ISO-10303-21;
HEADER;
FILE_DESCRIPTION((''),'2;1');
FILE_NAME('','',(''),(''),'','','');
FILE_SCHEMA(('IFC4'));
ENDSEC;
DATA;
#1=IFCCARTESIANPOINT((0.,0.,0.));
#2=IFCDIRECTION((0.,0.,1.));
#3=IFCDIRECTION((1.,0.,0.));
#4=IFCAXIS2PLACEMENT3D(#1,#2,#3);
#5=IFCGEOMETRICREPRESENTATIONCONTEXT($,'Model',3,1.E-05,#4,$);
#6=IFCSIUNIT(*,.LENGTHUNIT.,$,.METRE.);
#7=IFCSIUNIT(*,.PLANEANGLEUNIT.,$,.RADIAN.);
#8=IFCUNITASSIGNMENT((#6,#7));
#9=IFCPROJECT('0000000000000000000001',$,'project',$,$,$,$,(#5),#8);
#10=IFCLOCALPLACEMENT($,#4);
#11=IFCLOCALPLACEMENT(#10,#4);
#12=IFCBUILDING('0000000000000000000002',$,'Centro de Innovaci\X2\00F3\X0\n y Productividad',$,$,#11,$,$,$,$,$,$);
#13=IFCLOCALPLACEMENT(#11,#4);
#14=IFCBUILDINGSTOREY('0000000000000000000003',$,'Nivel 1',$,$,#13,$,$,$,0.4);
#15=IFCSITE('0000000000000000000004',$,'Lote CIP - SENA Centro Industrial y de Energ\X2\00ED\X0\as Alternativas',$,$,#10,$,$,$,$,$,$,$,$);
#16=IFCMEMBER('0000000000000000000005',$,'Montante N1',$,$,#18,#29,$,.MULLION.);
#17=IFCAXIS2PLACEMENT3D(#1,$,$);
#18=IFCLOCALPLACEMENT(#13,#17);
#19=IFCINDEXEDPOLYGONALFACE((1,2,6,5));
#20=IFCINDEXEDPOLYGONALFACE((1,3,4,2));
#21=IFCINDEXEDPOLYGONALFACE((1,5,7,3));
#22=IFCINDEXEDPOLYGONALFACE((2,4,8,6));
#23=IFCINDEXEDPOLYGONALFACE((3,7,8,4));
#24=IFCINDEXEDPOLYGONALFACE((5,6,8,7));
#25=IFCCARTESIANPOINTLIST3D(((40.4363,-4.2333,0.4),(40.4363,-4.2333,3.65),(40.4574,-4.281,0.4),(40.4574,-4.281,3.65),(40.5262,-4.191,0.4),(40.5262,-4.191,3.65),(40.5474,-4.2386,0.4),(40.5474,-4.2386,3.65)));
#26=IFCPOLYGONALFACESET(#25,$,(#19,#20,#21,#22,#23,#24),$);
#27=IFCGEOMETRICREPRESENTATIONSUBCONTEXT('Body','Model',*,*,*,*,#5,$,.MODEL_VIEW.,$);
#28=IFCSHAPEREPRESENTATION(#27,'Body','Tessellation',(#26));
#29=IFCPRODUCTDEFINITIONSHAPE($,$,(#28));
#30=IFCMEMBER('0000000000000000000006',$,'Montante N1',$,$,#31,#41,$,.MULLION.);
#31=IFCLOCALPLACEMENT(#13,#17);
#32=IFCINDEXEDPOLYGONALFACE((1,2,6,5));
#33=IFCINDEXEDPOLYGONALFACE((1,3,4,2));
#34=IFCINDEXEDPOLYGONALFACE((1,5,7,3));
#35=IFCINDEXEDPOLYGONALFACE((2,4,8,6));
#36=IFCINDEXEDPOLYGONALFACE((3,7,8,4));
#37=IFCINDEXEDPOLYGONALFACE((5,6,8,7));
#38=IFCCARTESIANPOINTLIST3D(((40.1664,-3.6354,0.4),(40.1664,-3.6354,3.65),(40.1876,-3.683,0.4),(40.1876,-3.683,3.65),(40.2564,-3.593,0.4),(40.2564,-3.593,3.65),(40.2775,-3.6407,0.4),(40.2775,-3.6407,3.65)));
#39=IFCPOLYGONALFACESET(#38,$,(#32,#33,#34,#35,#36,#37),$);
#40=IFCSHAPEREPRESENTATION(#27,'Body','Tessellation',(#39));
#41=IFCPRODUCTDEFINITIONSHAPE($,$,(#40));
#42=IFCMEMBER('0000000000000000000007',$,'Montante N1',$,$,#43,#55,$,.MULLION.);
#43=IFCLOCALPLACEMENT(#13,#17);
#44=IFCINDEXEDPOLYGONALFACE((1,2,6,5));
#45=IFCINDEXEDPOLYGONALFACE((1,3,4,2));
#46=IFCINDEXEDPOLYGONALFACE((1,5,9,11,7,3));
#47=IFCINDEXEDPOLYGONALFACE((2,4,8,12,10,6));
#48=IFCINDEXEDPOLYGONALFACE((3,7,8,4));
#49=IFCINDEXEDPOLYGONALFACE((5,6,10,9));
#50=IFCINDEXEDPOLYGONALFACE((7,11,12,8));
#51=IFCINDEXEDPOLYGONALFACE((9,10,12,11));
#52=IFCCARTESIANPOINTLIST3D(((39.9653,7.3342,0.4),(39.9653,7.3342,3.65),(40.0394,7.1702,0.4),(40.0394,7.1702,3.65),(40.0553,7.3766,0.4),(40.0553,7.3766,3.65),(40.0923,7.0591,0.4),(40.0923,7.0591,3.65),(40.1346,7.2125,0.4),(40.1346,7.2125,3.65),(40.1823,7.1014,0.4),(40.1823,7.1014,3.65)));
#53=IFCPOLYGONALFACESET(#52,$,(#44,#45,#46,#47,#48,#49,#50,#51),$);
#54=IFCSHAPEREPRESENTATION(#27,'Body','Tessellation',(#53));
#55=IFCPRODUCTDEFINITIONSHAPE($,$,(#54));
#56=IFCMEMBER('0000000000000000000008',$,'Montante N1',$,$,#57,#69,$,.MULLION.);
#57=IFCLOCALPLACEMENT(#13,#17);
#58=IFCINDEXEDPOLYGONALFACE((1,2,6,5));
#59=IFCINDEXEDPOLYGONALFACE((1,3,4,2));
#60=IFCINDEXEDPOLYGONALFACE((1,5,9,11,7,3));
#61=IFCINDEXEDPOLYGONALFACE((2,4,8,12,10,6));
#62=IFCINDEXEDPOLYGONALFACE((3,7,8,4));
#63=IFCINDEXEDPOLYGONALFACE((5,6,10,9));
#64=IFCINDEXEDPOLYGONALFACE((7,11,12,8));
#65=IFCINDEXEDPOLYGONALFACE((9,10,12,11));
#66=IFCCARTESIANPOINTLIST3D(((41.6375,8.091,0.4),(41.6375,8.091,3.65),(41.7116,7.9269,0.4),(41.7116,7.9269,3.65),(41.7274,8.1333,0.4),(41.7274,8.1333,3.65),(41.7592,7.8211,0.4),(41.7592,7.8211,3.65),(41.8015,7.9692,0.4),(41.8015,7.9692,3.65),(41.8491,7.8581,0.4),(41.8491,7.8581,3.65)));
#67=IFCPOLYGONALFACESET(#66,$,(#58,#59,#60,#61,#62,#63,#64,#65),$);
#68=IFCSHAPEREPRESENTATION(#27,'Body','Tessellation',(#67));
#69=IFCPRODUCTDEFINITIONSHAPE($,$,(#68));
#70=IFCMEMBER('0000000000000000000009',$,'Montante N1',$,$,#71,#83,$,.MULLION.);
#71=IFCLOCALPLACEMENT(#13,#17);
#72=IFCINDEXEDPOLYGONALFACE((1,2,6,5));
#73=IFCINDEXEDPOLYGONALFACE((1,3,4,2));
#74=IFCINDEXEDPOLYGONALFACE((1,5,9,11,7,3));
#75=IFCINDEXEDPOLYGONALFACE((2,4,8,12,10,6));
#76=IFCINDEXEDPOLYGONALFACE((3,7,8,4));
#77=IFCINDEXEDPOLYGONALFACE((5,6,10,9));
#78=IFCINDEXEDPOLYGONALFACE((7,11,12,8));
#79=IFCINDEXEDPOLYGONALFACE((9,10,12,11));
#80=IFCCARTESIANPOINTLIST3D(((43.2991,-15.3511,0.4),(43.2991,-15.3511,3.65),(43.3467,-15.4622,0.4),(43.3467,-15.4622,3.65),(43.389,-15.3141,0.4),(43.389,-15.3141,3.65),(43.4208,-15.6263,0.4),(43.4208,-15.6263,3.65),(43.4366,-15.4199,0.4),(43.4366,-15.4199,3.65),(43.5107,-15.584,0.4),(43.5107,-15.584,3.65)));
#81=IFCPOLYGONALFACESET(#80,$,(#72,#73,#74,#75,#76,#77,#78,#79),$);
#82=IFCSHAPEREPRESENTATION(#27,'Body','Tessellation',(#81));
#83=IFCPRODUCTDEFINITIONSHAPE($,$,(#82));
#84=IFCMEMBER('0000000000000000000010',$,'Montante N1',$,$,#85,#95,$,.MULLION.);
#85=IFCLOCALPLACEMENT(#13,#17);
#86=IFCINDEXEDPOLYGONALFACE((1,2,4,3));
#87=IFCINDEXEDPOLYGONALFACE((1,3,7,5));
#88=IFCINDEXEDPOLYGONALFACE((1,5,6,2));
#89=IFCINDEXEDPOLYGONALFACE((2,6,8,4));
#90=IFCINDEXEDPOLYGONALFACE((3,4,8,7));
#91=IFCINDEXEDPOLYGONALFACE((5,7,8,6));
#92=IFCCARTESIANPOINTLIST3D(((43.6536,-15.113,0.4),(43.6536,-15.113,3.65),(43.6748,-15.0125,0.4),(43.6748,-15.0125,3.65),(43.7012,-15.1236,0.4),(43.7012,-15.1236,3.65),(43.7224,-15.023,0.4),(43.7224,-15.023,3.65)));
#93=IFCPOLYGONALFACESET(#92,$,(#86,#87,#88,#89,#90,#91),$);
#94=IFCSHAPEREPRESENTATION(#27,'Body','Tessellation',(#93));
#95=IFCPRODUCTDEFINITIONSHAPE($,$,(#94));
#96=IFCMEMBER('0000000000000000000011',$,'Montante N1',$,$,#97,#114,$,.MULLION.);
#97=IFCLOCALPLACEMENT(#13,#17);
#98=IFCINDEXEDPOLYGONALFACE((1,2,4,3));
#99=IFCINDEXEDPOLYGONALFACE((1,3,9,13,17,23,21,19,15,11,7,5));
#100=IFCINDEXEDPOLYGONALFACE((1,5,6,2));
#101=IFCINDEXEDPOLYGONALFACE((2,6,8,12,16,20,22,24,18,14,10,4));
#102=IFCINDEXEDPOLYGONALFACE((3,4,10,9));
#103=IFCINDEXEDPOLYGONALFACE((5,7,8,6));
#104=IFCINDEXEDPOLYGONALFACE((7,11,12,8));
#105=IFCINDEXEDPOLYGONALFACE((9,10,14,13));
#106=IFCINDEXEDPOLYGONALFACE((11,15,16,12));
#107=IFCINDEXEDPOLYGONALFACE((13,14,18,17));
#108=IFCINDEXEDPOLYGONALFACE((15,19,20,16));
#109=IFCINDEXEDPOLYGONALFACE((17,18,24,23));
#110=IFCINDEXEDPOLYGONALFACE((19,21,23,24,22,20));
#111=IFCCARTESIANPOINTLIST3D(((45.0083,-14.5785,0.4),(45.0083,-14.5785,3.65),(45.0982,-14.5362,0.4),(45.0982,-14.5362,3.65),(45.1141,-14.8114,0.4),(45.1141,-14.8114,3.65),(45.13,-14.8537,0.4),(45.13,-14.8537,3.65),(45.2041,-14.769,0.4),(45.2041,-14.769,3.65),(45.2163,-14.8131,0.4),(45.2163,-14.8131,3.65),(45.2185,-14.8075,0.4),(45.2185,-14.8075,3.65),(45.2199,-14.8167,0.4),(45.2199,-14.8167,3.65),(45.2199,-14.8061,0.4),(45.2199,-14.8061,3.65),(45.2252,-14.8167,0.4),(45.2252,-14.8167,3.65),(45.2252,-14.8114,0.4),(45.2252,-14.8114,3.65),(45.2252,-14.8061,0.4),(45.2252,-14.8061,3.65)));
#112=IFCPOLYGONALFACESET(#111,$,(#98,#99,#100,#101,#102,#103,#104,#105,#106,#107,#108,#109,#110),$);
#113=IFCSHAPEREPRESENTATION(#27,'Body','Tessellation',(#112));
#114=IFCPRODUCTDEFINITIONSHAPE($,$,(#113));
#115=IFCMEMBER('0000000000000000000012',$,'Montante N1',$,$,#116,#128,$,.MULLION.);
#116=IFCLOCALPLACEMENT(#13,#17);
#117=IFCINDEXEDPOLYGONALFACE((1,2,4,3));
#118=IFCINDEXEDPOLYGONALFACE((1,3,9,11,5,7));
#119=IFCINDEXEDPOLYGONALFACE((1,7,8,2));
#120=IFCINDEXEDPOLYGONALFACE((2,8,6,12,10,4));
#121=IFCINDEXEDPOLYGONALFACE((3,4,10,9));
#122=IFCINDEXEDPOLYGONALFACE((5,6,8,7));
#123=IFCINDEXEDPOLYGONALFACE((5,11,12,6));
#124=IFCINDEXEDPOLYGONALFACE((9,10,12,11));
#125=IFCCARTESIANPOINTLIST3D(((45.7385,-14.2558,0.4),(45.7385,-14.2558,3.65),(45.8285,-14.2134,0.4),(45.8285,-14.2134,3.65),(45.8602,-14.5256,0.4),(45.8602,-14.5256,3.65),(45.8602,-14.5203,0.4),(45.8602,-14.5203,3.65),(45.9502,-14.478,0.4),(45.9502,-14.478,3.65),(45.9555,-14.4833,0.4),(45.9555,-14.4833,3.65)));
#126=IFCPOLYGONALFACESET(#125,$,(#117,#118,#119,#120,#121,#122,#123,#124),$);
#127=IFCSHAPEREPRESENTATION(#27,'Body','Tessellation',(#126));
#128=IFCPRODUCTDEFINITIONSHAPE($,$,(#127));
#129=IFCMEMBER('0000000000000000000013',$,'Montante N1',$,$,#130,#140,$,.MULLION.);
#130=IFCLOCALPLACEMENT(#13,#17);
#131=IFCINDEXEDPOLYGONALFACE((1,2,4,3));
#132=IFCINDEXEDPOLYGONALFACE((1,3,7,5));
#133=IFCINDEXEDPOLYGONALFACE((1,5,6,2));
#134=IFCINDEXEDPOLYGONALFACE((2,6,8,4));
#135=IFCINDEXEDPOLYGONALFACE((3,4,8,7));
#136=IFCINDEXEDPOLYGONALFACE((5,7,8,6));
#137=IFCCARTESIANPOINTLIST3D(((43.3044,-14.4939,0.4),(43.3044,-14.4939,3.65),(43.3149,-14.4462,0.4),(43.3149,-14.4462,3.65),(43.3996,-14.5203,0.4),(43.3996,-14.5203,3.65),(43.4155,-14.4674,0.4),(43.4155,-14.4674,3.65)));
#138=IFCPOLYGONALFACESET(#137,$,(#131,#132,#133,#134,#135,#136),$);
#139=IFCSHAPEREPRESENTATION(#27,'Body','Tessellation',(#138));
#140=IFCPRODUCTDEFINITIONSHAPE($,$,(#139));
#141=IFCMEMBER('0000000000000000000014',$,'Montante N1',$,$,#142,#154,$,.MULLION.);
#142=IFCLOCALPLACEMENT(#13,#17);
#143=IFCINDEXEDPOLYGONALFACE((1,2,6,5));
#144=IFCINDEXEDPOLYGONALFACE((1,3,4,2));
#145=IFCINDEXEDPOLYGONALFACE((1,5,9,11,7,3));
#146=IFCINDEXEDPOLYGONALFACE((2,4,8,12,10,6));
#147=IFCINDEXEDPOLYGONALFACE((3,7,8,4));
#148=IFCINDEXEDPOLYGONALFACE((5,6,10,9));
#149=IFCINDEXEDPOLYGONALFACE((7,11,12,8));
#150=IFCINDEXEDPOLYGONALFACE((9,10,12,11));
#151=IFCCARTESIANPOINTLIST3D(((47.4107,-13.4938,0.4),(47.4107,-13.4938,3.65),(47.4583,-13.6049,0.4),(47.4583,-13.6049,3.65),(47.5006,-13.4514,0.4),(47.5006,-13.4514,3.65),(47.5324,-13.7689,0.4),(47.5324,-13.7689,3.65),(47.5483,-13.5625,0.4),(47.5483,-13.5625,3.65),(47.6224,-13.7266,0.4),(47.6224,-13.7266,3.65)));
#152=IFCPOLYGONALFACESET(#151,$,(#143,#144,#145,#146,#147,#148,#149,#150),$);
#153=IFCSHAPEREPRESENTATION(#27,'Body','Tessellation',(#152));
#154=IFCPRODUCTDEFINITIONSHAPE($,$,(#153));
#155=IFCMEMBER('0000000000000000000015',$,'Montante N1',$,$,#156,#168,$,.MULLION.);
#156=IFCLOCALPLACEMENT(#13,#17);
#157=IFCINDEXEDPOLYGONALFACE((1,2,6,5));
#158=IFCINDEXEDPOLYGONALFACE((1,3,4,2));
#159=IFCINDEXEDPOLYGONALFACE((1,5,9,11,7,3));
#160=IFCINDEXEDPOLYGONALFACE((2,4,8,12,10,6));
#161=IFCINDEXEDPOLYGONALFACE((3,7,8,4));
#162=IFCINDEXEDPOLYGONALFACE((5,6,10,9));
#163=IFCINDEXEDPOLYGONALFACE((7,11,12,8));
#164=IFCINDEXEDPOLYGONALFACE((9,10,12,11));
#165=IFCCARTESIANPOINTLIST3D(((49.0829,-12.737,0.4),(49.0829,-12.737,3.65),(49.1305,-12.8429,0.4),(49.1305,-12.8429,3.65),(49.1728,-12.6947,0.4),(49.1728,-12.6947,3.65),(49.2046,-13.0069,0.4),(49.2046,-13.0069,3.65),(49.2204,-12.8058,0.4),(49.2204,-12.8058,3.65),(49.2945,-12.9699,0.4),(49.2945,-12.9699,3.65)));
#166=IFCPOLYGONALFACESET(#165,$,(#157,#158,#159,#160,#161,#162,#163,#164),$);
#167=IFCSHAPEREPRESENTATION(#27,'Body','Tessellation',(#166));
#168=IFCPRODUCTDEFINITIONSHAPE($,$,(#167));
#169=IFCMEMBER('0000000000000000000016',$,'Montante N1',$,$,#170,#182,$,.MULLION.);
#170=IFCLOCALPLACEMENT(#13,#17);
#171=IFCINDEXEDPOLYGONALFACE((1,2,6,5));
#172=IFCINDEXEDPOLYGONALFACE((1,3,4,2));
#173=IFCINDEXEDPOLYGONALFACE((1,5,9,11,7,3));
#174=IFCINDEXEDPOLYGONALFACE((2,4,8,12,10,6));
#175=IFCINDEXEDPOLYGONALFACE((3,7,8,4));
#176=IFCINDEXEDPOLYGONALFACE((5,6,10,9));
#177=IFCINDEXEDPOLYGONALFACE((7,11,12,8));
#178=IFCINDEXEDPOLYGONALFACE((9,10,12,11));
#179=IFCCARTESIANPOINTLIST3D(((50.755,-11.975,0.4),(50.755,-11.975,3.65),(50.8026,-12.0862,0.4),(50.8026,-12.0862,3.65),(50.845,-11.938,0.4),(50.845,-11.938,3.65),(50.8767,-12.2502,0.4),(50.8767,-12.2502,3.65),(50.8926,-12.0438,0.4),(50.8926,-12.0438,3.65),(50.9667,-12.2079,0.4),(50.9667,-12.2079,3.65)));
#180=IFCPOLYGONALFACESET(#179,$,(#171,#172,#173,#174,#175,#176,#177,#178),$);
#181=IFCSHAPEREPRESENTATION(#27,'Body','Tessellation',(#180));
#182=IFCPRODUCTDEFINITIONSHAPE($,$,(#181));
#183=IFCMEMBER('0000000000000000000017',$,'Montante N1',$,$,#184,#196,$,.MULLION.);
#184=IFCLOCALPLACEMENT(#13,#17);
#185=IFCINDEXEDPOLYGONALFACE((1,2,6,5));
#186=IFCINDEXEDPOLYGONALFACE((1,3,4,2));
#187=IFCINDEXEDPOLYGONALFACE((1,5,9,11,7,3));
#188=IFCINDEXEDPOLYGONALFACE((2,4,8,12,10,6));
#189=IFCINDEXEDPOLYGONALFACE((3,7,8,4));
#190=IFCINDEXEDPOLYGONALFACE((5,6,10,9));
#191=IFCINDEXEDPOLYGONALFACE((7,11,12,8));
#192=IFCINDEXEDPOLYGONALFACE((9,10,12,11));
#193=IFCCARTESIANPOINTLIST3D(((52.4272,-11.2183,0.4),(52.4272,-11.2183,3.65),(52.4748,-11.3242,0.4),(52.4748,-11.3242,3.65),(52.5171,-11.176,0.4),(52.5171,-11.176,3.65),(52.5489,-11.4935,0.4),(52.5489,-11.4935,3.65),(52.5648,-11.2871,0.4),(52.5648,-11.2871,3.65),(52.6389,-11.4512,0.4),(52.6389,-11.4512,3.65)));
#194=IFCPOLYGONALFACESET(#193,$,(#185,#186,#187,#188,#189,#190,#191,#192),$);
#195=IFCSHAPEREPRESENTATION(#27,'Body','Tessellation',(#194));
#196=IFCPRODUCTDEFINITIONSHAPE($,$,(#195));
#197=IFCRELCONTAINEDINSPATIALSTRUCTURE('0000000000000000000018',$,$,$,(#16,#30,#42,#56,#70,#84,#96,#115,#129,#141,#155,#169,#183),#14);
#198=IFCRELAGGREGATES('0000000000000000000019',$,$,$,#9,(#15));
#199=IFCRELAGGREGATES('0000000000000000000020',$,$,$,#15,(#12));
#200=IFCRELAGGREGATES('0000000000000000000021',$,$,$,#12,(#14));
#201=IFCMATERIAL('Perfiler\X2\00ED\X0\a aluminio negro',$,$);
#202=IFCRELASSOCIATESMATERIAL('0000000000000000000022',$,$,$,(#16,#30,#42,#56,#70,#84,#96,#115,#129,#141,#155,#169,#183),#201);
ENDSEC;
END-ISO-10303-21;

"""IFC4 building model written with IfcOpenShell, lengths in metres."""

from ifc_helpers import new_model, si_unit, frame, origin_with_axes, place, context, subcontext, project, spatial, polyline, outline, extrude, material, element, save


model = new_model("IFC4")

# Units and contexts
model_context = context("Model", 3, precision=1e-05, world=origin_with_axes())
body_context = subcontext(model_context, "Body", "Model", "MODEL_VIEW")
ifc_project = project(units=[si_unit("LENGTHUNIT", "METRE"), si_unit("PLANEANGLEUNIT", "RADIAN")], contexts=[model_context])

# Site, building, storey
site_placement = place(None, origin_with_axes())
site = spatial("IfcSite", under=ifc_project, at=site_placement, Name="Lote CIP - SENA Centro Industrial y de Energías Alternativas")
building_placement = place(site_placement, origin_with_axes())
building = spatial("IfcBuilding", under=site, at=building_placement, Name="Centro de Innovación y Productividad")
storey_placement = place(building_placement, origin_with_axes())
storey = spatial("IfcBuildingStorey", under=building, at=storey_placement, Name="Nivel 1", Elevation=0.4)

# Members
ifc_material = material(Name="Perfilería aluminio negro")
member_1_placement = place(storey_placement, origin_with_axes())
element("IfcMember", 1, at=member_1_placement, inside=storey, material=ifc_material, Name="Montante N1", PredefinedType="MULLION", context=body_context, shape_type="SweptSolid", body=[
    extrude(outline(polyline([(40.4574, -4.281), (40.4363, -4.2333), (40.5262, -4.191), (40.5474, -4.2386), (40.4574, -4.281)])), frame((0.0, 0.0, 0.4)), (0.0, 0.0, 1.0), 3.25),
])
member_2_placement = place(storey_placement, origin_with_axes())
element("IfcMember", 2, at=member_2_placement, inside=storey, material=ifc_material, Name="Montante N1", PredefinedType="MULLION", context=body_context, shape_type="SweptSolid", body=[
    extrude(outline(polyline([(40.1876, -3.683), (40.1664, -3.6354), (40.2564, -3.593), (40.2775, -3.6407), (40.1876, -3.683)])), frame((0.0, 0.0, 0.4)), (0.0, 0.0, 1.0), 3.25),
])
member_3_placement = place(storey_placement, origin_with_axes())
element("IfcMember", 3, at=member_3_placement, inside=storey, material=ifc_material, Name="Montante N1", PredefinedType="MULLION", context=body_context, shape_type="SweptSolid", body=[
    extrude(outline(polyline([(40.1346, 7.2125), (40.1823, 7.1014), (40.0923, 7.0591), (40.0394, 7.1702), (39.9653, 7.3342), (40.0553, 7.3766), (40.1346, 7.2125)])), frame((0.0, 0.0, 0.4)), (0.0, 0.0, 1.0), 3.25),
])
member_4_placement = place(storey_placement, origin_with_axes())
element("IfcMember", 4, at=member_4_placement, inside=storey, material=ifc_material, Name="Montante N1", PredefinedType="MULLION", context=body_context, shape_type="SweptSolid", body=[
    extrude(outline(polyline([(41.6375, 8.091), (41.7274, 8.1333), (41.8015, 7.9692), (41.8491, 7.8581), (41.7592, 7.8211), (41.7116, 7.9269), (41.6375, 8.091)])), frame((0.0, 0.0, 0.4)), (0.0, 0.0, 1.0), 3.25),
])
member_5_placement = place(storey_placement, origin_with_axes())
element("IfcMember", 5, at=member_5_placement, inside=storey, material=ifc_material, Name="Montante N1", PredefinedType="MULLION", context=body_context, shape_type="SweptSolid", body=[
    extrude(outline(polyline([(43.389, -15.3141), (43.4366, -15.4199), (43.5107, -15.584), (43.4208, -15.6263), (43.3467, -15.4623), (43.2991, -15.3511), (43.389, -15.3141)])), frame((0.0, 0.0, 0.4)), (0.0, 0.0, 1.0), 3.25),
])
member_6_placement = place(storey_placement, origin_with_axes())
element("IfcMember", 6, at=member_6_placement, inside=storey, material=ifc_material, Name="Montante N1", PredefinedType="MULLION", context=body_context, shape_type="SweptSolid", body=[
    extrude(outline(polyline([(43.6536, -15.113), (43.6748, -15.0125), (43.7224, -15.023), (43.7012, -15.1236), (43.6536, -15.113)])), frame((0.0, 0.0, 0.4)), (0.0, 0.0, 1.0), 3.25),
])
member_7_placement = place(storey_placement, origin_with_axes())
element("IfcMember", 7, at=member_7_placement, inside=storey, material=ifc_material, Name="Montante N1", PredefinedType="MULLION", context=body_context, shape_type="SweptSolid", body=[
    extrude(outline(polyline([(45.2199, -14.8061), (45.2252, -14.8061), (45.2252, -14.8114), (45.2252, -14.8167), (45.2199, -14.8167), (45.2163, -14.8131), (45.13, -14.8537), (45.1141, -14.8114), (45.0083, -14.5785), (45.0982, -14.5362), (45.2041, -14.769), (45.2185, -14.8075), (45.2199, -14.8061)])), frame((0.0, 0.0, 0.4)), (0.0, 0.0, 1.0), 3.25),
])
member_8_placement = place(storey_placement, origin_with_axes())
element("IfcMember", 8, at=member_8_placement, inside=storey, material=ifc_material, Name="Montante N1", PredefinedType="MULLION", context=body_context, shape_type="SweptSolid", body=[
    extrude(outline(polyline([(45.8602, -14.5203), (45.7385, -14.2558), (45.8285, -14.2134), (45.9502, -14.478), (45.9555, -14.4833), (45.8602, -14.5256), (45.8602, -14.5203)])), frame((0.0, 0.0, 0.4)), (0.0, 0.0, 1.0), 3.25),
])
member_9_placement = place(storey_placement, origin_with_axes())
element("IfcMember", 9, at=member_9_placement, inside=storey, material=ifc_material, Name="Montante N1", PredefinedType="MULLION", context=body_context, shape_type="SweptSolid", body=[
    extrude(outline(polyline([(43.3044, -14.4939), (43.3149, -14.4462), (43.4155, -14.4674), (43.3996, -14.5203), (43.3044, -14.4939)])), frame((0.0, 0.0, 0.4)), (0.0, 0.0, 1.0), 3.25),
])
member_10_placement = place(storey_placement, origin_with_axes())
element("IfcMember", 10, at=member_10_placement, inside=storey, material=ifc_material, Name="Montante N1", PredefinedType="MULLION", context=body_context, shape_type="SweptSolid", body=[
    extrude(outline(polyline([(47.5006, -13.4514), (47.5483, -13.5625), (47.6224, -13.7266), (47.5324, -13.7689), (47.4583, -13.6049), (47.4107, -13.4938), (47.5006, -13.4514)])), frame((0.0, 0.0, 0.4)), (0.0, 0.0, 1.0), 3.25),
])
member_11_placement = place(storey_placement, origin_with_axes())
element("IfcMember", 11, at=member_11_placement, inside=storey, material=ifc_material, Name="Montante N1", PredefinedType="MULLION", context=body_context, shape_type="SweptSolid", body=[
    extrude(outline(polyline([(49.2204, -12.8058), (49.2945, -12.9699), (49.2046, -13.0069), (49.1305, -12.8429), (49.0829, -12.737), (49.1728, -12.6947), (49.2204, -12.8058)])), frame((0.0, 0.0, 0.4)), (0.0, 0.0, 1.0), 3.25),
])
member_12_placement = place(storey_placement, origin_with_axes())
element("IfcMember", 12, at=member_12_placement, inside=storey, material=ifc_material, Name="Montante N1", PredefinedType="MULLION", context=body_context, shape_type="SweptSolid", body=[
    extrude(outline(polyline([(50.755, -11.975), (50.845, -11.938), (50.8926, -12.0438), (50.9667, -12.2079), (50.8767, -12.2502), (50.8026, -12.0862), (50.755, -11.975)])), frame((0.0, 0.0, 0.4)), (0.0, 0.0, 1.0), 3.25),
])
member_13_placement = place(storey_placement, origin_with_axes())
element("IfcMember", 13, at=member_13_placement, inside=storey, material=ifc_material, Name="Montante N1", PredefinedType="MULLION", context=body_context, shape_type="SweptSolid", body=[
    extrude(outline(polyline([(52.5489, -11.4935), (52.4748, -11.3242), (52.4272, -11.2183), (52.5171, -11.176), (52.5648, -11.2871), (52.6389, -11.4512), (52.5489, -11.4935)])), frame((0.0, 0.0, 0.4)), (0.0, 0.0, 1.0), 3.25),
])

save(model, "model.ifc")
